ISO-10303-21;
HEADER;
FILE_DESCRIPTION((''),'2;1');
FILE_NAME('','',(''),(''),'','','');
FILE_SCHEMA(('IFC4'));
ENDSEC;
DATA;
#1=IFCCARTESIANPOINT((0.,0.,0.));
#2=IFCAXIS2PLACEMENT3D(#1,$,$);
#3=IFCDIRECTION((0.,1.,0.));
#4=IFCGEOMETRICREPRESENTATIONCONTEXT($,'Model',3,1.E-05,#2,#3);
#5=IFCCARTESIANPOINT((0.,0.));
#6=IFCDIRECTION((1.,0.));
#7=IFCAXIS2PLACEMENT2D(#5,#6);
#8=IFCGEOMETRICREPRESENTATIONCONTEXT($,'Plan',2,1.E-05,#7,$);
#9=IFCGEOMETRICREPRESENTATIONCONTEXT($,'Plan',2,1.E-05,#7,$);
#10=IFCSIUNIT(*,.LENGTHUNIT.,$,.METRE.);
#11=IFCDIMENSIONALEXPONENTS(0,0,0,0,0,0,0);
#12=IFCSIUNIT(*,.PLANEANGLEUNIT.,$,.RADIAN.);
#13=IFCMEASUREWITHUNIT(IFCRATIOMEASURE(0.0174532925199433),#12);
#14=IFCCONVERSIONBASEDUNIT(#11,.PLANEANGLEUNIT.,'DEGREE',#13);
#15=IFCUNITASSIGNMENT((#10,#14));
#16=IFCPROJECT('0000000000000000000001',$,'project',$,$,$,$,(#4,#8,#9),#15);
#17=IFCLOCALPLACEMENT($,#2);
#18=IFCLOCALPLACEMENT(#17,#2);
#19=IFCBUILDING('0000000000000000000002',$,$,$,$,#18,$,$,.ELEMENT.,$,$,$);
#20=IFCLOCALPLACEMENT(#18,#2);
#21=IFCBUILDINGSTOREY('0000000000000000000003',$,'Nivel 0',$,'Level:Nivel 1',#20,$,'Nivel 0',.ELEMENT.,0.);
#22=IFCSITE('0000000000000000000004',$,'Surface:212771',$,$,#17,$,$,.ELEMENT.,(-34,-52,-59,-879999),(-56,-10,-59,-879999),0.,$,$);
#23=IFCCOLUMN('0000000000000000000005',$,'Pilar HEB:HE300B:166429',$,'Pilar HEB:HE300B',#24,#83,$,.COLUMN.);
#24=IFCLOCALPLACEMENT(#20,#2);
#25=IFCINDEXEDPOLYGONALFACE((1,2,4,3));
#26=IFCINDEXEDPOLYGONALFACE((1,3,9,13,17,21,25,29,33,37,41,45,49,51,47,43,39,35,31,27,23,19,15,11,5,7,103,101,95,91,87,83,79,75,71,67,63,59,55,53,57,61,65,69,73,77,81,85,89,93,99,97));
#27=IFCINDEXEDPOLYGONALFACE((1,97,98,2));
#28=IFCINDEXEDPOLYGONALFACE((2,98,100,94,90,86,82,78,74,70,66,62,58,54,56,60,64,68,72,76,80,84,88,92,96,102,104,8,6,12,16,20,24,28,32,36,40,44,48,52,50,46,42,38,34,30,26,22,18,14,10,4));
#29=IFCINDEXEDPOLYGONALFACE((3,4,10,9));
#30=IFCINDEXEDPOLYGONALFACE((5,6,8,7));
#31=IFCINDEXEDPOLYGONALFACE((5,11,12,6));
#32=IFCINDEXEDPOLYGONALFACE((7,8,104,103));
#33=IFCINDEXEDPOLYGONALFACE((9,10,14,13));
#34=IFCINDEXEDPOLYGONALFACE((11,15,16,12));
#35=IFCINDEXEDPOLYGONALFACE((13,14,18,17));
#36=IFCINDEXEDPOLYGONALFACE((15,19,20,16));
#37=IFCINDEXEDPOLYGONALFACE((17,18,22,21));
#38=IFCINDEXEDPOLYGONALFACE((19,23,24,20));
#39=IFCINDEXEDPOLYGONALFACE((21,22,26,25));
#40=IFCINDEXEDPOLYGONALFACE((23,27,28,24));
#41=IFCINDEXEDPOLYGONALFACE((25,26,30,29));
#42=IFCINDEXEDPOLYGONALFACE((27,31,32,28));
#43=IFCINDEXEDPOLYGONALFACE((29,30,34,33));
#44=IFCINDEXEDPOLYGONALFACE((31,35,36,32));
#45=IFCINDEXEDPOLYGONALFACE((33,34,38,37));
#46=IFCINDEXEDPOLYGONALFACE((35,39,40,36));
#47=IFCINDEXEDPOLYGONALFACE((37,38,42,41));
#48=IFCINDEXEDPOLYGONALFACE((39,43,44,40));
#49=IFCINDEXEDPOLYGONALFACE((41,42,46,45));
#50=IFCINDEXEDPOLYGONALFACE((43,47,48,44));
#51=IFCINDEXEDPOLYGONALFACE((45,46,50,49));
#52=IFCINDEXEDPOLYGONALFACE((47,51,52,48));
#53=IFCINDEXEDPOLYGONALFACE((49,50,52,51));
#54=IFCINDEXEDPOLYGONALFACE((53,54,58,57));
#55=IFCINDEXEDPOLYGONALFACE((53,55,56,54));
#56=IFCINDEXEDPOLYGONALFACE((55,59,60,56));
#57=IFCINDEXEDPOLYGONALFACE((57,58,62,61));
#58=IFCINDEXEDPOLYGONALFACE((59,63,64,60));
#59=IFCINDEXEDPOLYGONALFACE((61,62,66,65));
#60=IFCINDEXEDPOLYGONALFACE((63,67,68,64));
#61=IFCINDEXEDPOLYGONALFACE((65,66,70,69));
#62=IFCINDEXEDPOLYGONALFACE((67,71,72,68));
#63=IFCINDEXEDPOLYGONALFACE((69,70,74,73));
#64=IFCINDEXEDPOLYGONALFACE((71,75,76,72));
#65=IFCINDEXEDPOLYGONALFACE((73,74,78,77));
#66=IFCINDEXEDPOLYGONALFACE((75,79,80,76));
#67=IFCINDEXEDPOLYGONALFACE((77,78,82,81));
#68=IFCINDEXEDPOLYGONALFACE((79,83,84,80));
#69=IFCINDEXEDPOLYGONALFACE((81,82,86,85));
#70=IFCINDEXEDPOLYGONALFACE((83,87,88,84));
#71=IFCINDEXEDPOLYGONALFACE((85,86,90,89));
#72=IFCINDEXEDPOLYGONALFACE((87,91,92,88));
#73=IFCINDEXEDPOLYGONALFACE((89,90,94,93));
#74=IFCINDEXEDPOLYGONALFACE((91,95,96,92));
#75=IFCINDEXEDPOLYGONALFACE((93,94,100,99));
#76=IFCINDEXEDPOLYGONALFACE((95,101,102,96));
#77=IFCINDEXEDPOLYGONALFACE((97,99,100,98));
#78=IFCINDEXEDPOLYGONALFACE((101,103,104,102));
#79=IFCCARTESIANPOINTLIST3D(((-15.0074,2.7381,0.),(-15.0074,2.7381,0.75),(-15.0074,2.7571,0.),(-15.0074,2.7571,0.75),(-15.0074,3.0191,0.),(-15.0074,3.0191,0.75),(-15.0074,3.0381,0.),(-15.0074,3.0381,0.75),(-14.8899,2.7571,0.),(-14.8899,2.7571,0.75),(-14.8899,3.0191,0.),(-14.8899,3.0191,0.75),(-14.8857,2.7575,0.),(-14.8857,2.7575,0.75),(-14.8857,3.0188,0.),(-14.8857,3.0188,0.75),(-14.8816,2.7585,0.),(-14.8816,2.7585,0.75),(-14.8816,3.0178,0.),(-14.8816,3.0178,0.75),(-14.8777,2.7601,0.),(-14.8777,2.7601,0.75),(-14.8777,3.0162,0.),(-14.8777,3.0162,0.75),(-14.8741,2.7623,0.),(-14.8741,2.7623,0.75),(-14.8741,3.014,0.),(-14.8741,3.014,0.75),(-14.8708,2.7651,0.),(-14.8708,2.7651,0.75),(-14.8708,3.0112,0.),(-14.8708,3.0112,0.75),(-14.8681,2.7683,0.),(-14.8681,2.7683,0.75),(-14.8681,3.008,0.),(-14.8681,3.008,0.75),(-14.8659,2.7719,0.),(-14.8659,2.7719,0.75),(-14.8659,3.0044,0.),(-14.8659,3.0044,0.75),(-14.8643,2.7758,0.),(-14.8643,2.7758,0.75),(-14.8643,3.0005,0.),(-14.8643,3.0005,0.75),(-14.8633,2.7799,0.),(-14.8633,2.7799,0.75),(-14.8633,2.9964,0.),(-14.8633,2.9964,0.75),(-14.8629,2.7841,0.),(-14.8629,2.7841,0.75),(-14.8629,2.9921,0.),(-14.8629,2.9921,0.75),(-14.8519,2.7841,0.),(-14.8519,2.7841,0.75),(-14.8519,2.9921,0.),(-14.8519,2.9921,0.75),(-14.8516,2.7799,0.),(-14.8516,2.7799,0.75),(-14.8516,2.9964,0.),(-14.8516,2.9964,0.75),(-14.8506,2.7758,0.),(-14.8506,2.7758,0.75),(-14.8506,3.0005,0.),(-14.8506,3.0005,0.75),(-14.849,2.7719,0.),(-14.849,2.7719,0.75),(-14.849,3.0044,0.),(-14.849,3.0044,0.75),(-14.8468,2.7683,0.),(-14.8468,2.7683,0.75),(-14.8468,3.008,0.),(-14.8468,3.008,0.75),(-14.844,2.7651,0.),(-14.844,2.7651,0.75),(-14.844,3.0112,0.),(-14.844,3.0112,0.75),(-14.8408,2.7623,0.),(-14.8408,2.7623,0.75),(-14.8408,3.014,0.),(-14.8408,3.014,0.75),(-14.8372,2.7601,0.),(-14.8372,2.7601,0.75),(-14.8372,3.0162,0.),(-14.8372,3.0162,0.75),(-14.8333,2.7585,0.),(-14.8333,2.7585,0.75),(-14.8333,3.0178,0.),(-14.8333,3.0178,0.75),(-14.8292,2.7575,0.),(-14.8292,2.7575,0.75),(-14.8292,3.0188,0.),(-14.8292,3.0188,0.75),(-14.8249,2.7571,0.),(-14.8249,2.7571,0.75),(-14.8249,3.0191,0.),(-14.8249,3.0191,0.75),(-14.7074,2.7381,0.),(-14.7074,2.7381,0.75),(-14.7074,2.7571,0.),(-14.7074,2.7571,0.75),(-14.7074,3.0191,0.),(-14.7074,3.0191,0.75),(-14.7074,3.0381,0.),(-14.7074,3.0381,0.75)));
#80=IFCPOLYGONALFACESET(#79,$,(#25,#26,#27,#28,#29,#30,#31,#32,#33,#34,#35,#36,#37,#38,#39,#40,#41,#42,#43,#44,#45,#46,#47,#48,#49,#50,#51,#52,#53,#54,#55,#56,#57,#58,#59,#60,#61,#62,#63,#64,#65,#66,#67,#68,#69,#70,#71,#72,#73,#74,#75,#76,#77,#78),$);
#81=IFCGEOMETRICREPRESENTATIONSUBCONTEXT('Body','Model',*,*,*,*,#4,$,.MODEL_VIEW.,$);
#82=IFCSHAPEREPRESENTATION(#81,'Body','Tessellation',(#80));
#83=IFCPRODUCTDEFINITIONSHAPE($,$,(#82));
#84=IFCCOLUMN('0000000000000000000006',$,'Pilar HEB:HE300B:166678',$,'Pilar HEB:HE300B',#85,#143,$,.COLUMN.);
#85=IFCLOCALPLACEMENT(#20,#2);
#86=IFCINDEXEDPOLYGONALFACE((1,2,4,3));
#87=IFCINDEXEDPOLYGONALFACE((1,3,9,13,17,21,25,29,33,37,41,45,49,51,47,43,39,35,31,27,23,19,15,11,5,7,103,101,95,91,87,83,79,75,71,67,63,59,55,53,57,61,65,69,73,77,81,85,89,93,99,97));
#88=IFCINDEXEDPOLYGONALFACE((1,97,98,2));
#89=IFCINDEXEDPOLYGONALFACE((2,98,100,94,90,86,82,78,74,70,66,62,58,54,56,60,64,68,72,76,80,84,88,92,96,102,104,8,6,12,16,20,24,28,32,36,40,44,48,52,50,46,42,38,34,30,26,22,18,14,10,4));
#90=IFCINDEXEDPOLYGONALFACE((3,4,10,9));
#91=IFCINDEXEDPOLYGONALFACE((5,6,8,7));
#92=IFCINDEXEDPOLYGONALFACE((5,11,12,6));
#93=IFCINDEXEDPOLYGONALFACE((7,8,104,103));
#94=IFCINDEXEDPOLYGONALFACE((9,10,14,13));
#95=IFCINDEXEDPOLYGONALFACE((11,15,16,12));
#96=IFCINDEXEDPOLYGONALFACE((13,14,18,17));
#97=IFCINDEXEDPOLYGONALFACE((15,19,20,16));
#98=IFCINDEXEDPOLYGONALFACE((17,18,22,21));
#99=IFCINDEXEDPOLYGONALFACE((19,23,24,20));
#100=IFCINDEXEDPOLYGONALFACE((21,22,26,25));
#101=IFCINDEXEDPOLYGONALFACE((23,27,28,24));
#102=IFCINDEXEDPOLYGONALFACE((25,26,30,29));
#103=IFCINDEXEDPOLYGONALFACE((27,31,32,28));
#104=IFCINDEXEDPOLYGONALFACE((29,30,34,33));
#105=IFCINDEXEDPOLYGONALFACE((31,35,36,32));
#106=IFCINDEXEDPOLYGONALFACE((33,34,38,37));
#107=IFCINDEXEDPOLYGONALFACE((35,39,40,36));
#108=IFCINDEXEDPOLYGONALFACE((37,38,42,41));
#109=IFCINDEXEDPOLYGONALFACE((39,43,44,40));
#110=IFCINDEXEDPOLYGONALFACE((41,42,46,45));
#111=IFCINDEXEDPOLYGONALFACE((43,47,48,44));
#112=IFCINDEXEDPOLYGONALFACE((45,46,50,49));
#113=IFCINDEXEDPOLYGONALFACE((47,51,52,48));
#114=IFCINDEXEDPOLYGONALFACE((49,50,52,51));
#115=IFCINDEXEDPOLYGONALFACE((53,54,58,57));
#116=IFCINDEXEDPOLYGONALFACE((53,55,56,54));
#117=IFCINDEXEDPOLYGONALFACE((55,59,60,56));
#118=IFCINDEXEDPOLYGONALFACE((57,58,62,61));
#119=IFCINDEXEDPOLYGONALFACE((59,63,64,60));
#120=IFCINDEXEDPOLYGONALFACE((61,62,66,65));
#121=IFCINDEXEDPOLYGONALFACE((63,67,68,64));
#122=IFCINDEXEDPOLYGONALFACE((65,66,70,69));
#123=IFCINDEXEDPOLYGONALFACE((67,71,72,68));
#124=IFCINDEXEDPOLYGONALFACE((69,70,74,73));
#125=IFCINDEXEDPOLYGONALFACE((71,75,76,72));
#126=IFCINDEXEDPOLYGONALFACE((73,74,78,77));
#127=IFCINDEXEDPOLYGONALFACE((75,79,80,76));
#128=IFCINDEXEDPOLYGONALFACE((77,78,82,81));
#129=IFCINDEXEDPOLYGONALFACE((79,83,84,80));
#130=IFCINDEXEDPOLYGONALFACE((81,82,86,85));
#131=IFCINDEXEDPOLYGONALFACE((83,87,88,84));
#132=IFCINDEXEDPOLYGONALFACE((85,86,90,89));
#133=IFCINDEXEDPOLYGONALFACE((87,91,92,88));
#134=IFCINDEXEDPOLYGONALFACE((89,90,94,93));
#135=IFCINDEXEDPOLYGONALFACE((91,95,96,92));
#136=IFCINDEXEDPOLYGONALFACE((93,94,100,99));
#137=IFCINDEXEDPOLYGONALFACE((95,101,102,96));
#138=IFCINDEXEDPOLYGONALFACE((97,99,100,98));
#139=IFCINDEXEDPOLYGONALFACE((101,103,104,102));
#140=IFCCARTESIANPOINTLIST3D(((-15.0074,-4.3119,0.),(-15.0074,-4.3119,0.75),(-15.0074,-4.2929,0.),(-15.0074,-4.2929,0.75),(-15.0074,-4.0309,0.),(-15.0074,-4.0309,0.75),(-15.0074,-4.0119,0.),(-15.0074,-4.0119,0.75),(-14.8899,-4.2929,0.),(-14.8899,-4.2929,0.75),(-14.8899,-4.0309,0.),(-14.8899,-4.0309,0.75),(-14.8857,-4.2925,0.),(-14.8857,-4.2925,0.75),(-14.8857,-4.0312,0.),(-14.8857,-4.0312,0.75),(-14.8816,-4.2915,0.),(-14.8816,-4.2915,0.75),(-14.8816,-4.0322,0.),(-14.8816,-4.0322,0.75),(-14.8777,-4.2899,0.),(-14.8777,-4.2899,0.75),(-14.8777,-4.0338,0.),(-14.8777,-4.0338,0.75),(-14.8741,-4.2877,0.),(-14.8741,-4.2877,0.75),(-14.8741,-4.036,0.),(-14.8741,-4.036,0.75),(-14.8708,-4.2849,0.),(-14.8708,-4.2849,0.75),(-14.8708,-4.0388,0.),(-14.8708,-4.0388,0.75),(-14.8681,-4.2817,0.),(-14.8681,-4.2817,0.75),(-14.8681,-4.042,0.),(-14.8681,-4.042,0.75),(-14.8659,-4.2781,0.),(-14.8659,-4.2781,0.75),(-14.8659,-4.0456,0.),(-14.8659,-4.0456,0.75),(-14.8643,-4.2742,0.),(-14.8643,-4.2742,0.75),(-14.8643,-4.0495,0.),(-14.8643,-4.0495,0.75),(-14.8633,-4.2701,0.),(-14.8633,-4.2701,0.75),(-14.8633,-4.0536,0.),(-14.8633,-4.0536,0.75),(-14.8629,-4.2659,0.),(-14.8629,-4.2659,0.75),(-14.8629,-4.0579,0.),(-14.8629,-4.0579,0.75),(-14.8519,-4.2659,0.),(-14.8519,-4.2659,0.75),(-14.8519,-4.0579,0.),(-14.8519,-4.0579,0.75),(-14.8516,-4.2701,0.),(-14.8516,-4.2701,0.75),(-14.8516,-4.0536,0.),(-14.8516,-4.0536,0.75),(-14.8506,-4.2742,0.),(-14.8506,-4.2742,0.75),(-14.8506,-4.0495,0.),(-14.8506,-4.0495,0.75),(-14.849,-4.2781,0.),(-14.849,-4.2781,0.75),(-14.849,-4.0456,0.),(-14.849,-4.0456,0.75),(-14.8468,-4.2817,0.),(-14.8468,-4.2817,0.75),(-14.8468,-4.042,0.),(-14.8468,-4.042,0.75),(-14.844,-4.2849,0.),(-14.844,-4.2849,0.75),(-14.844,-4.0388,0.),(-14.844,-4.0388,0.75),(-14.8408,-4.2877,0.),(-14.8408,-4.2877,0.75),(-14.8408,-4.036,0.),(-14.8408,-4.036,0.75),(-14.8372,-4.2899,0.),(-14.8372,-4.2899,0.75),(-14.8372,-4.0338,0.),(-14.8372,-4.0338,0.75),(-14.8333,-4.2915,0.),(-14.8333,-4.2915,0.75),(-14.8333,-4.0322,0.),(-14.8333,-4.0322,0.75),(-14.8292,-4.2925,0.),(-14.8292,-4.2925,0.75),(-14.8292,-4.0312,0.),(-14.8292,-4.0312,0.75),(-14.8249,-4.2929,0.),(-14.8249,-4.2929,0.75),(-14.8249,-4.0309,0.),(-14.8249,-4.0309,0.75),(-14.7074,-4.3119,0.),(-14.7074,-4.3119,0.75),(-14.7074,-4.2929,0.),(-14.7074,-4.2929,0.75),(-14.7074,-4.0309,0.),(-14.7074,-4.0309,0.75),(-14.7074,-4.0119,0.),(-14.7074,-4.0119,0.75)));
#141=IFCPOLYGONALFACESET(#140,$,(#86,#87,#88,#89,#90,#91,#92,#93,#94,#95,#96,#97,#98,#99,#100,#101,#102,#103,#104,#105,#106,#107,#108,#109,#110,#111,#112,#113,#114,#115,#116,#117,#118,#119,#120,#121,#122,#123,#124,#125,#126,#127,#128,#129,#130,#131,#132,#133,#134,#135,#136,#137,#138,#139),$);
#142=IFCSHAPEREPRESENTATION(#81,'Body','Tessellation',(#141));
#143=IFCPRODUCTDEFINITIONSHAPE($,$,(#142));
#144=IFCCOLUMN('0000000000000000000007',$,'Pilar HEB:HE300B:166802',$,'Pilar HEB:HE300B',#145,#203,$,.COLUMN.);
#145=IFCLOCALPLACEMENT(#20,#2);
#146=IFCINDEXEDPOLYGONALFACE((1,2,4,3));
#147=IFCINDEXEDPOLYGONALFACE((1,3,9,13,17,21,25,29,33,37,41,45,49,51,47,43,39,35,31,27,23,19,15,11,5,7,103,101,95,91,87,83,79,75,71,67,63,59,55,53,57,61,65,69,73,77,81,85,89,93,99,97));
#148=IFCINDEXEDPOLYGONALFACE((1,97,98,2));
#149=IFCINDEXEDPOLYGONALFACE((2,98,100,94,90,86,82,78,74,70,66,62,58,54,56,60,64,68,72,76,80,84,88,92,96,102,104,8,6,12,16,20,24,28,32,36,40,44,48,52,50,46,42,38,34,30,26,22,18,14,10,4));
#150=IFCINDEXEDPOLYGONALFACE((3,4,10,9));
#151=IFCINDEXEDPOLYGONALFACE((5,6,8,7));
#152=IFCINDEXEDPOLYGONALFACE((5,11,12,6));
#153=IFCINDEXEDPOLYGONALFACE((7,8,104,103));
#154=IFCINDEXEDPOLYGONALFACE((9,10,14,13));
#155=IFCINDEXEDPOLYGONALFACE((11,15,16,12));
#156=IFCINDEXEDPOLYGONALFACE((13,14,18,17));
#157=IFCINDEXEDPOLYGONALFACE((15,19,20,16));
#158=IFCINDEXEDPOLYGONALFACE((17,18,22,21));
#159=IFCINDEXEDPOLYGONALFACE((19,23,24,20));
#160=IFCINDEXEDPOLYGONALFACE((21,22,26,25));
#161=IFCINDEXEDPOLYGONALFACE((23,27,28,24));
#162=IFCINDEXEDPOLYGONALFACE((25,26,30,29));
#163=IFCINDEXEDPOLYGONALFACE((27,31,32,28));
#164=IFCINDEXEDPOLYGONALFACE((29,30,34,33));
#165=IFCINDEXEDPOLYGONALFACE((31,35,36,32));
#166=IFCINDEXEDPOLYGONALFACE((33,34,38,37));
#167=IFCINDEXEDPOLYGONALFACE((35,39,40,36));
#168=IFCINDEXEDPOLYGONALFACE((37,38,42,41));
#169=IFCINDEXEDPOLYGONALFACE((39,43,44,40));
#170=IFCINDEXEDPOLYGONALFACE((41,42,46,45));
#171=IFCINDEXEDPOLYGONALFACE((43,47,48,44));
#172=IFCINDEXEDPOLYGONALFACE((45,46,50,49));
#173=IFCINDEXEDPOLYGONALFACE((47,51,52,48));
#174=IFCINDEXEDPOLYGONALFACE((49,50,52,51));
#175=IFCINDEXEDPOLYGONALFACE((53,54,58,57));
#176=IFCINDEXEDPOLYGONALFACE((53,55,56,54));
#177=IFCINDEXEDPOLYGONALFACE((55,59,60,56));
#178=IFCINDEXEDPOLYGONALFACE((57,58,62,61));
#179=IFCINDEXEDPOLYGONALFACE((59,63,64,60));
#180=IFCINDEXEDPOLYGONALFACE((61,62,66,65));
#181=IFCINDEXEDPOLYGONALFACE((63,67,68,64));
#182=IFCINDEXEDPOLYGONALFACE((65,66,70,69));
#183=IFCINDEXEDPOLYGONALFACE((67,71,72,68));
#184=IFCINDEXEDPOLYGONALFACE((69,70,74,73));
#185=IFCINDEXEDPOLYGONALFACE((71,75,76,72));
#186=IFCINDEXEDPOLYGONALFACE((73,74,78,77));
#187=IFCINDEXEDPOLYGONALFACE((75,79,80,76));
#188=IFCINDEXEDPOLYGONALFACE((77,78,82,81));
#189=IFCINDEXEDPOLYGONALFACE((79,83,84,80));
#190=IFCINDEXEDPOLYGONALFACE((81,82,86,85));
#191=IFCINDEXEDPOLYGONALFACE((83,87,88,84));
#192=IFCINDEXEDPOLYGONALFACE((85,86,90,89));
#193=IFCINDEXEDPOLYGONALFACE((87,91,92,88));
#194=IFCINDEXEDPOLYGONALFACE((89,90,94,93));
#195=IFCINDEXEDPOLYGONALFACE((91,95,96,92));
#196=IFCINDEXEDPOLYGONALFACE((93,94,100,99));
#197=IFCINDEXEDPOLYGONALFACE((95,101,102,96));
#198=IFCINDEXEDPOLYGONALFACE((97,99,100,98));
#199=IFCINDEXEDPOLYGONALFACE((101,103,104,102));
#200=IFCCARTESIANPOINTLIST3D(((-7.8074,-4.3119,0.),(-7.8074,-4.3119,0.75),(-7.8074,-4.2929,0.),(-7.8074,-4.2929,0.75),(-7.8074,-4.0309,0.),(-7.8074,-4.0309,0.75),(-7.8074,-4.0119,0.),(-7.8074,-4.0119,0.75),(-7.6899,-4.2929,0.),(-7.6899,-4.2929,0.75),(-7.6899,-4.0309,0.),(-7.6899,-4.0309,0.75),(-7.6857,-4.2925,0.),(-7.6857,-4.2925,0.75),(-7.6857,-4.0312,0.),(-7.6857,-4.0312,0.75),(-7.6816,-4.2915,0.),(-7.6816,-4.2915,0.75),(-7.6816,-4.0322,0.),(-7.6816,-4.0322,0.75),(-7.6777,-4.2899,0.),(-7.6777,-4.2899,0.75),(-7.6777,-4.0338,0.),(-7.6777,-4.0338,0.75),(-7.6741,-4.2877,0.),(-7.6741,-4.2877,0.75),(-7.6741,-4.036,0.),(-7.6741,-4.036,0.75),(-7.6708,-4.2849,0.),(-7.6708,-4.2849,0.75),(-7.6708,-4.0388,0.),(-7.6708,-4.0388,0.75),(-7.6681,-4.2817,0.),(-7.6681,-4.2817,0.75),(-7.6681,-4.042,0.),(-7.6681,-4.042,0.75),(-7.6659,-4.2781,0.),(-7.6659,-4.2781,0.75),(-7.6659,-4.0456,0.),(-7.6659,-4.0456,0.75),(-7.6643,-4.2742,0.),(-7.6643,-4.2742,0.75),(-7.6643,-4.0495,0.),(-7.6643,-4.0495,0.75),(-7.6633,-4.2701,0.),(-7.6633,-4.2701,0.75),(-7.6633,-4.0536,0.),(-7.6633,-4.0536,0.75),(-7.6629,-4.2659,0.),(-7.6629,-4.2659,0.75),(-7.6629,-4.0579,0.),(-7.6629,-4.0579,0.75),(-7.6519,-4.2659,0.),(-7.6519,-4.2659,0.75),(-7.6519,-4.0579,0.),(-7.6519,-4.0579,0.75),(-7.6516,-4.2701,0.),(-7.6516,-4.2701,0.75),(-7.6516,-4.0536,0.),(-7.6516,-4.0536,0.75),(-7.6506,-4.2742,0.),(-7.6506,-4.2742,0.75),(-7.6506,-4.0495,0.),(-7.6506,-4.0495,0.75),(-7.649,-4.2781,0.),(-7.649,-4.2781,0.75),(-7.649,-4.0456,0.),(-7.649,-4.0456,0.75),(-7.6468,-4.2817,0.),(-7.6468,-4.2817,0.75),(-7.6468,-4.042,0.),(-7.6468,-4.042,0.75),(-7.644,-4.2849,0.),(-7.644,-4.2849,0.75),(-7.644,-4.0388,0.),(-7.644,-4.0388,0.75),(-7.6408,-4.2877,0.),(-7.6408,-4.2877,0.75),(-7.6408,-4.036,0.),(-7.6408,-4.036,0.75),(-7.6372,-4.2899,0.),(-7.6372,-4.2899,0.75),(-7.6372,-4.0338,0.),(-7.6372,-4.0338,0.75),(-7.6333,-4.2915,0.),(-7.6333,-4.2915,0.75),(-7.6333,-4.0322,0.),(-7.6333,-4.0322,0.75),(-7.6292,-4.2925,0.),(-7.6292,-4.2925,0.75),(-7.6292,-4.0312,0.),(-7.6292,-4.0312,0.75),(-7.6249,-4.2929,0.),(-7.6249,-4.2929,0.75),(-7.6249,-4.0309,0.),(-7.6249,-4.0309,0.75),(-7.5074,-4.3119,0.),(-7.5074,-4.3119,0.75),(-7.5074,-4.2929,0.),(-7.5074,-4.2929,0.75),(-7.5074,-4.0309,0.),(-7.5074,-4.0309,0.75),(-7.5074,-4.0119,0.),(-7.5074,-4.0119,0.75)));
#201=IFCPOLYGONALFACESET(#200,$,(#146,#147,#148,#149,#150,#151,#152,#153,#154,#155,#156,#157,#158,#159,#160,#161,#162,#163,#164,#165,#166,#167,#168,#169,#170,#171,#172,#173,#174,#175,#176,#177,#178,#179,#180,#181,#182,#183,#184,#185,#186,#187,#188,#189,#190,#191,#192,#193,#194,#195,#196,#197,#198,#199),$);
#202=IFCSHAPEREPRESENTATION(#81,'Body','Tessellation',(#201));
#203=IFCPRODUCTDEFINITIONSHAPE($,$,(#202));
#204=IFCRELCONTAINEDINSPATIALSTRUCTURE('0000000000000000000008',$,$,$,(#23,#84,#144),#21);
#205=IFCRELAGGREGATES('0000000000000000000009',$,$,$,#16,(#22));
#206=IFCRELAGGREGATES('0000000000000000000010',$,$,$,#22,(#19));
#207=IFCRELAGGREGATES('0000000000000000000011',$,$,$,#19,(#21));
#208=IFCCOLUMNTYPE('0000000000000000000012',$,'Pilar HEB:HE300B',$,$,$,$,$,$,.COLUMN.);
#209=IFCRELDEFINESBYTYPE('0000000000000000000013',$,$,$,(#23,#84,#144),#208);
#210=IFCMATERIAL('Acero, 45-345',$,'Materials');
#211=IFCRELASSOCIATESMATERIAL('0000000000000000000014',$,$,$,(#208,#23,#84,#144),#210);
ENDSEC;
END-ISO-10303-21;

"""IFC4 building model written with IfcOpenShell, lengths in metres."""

from ifc_helpers import new_model, entity, si_unit, converted_unit, direction, frame, origin, origin_2d_with_axis, place, context, subcontext, project, spatial, indexed_curve, outline, extrude, source, transform, mapped, material, type_object, type_shapes, element, save


model = new_model("IFC4")

# Units and contexts
model_context = context("Model", 3, precision=1e-05, world=origin(), true_north=direction((0.0, 1.0, 0.0)))
plan_context_1 = context("Plan", 2, precision=1e-05, world=origin_2d_with_axis())
plan_context_2 = context("Plan", 2, precision=1e-05, world=origin_2d_with_axis())
body_context = subcontext(model_context, "Body", "Model", "MODEL_VIEW")
ifc_project = project(units=[si_unit("LENGTHUNIT", "METRE"), converted_unit("PLANEANGLEUNIT", "DEGREE", entity("IfcRatioMeasure", 0.0174532925199433), si_unit("PLANEANGLEUNIT", "RADIAN"), dimensions=[0, 0, 0, 0, 0, 0, 0])], contexts=[model_context, plan_context_1, plan_context_2])

# Site, building, storey
site_placement = place(None, origin())
site = spatial("IfcSite", under=ifc_project, at=site_placement, Name="Surface:212771", CompositionType="ELEMENT", RefLatitude=(-34, -52, -59, -879999), RefLongitude=(-56, -10, -59, -879999), RefElevation=0.0)
building_placement = place(site_placement, origin())
building = spatial("IfcBuilding", under=site, at=building_placement, CompositionType="ELEMENT")
storey_placement = place(building_placement, origin())
storey = spatial("IfcBuildingStorey", under=building, at=storey_placement, Name="Nivel 0", ObjectType="Level:Nivel 1", LongName="Nivel 0", CompositionType="ELEMENT", Elevation=0.0)

# Columns
ifc_material_1 = material(Name="Acero, 45-345", Category="Materials")
column_type_1 = type_object("IfcColumnType", Name="Pilar HEB:HE300B", PredefinedType="COLUMN", material=ifc_material_1)
shared_shape_1 = source(origin(), body_context, "Body", "SweptSolid", [
    extrude(outline(indexed_curve([(-0.15, -0.15), (-0.131, -0.15), (-0.131, -0.0325), (-0.1307, -0.0283), (-0.1297, -0.0242), (-0.1281, -0.0202), (-0.1258, -0.0166), (-0.1231, -0.0134), (-0.1199, -0.0107), (-0.1163, -0.0084), (-0.1123, -0.0068), (-0.1082, -0.0058), (-0.104, -0.0055), (0.104, -0.0055), (0.1082, -0.0058), (0.1123, -0.0068), (0.1163, -0.0084), (0.1199, -0.0107), (0.1231, -0.0134), (0.1258, -0.0166), (0.1281, -0.0202), (0.1297, -0.0242), (0.1307, -0.0283), (0.131, -0.0325), (0.131, -0.15), (0.15, -0.15), (0.15, 0.15), (0.131, 0.15), (0.131, 0.0325), (0.1307, 0.0283), (0.1297, 0.0242), (0.1281, 0.0202), (0.1258, 0.0166), (0.1231, 0.0134), (0.1199, 0.0107), (0.1163, 0.0084), (0.1123, 0.0068), (0.1082, 0.0058), (0.104, 0.0055), (-0.104, 0.0055), (-0.1082, 0.0058), (-0.1123, 0.0068), (-0.1163, 0.0084), (-0.1199, 0.0107), (-0.1231, 0.0134), (-0.1258, 0.0166), (-0.1281, 0.0202), (-0.1297, 0.0242), (-0.1307, 0.0283), (-0.131, 0.0325), (-0.131, 0.15), (-0.15, 0.15), (-0.15, -0.15)], self_intersect=False)), frame((0.0, 0.0, 0.0), z_axis=(0.0, 0.0, 1.0), x_axis=(0.0, -1.0, 0.0)), (0.0, 0.0, 1.0), 0.75),
])
type_shapes(column_type_1, [shared_shape_1])
for number, where, name in (
    (1, (-14.8574, 2.8881, 0.0), "Pilar HEB:HE300B:166429"),
    (2, (-14.8574, -4.1619, 0.0), "Pilar HEB:HE300B:166678"),
    (3, (-7.6574, -4.1619, 0.0), "Pilar HEB:HE300B:166802"),
):
    element("IfcColumn", number, at=place(storey_placement, frame(where)), inside=storey, type_object=column_type_1, material=ifc_material_1, Name=name, ObjectType="Pilar HEB:HE300B", PredefinedType="COLUMN", context=body_context, shape_type="MappedRepresentation", body=[
        mapped(shared_shape_1, transform((0.0, 0.0, 0.0), scale=1.0)),
    ])

save(model, "model.ifc")
